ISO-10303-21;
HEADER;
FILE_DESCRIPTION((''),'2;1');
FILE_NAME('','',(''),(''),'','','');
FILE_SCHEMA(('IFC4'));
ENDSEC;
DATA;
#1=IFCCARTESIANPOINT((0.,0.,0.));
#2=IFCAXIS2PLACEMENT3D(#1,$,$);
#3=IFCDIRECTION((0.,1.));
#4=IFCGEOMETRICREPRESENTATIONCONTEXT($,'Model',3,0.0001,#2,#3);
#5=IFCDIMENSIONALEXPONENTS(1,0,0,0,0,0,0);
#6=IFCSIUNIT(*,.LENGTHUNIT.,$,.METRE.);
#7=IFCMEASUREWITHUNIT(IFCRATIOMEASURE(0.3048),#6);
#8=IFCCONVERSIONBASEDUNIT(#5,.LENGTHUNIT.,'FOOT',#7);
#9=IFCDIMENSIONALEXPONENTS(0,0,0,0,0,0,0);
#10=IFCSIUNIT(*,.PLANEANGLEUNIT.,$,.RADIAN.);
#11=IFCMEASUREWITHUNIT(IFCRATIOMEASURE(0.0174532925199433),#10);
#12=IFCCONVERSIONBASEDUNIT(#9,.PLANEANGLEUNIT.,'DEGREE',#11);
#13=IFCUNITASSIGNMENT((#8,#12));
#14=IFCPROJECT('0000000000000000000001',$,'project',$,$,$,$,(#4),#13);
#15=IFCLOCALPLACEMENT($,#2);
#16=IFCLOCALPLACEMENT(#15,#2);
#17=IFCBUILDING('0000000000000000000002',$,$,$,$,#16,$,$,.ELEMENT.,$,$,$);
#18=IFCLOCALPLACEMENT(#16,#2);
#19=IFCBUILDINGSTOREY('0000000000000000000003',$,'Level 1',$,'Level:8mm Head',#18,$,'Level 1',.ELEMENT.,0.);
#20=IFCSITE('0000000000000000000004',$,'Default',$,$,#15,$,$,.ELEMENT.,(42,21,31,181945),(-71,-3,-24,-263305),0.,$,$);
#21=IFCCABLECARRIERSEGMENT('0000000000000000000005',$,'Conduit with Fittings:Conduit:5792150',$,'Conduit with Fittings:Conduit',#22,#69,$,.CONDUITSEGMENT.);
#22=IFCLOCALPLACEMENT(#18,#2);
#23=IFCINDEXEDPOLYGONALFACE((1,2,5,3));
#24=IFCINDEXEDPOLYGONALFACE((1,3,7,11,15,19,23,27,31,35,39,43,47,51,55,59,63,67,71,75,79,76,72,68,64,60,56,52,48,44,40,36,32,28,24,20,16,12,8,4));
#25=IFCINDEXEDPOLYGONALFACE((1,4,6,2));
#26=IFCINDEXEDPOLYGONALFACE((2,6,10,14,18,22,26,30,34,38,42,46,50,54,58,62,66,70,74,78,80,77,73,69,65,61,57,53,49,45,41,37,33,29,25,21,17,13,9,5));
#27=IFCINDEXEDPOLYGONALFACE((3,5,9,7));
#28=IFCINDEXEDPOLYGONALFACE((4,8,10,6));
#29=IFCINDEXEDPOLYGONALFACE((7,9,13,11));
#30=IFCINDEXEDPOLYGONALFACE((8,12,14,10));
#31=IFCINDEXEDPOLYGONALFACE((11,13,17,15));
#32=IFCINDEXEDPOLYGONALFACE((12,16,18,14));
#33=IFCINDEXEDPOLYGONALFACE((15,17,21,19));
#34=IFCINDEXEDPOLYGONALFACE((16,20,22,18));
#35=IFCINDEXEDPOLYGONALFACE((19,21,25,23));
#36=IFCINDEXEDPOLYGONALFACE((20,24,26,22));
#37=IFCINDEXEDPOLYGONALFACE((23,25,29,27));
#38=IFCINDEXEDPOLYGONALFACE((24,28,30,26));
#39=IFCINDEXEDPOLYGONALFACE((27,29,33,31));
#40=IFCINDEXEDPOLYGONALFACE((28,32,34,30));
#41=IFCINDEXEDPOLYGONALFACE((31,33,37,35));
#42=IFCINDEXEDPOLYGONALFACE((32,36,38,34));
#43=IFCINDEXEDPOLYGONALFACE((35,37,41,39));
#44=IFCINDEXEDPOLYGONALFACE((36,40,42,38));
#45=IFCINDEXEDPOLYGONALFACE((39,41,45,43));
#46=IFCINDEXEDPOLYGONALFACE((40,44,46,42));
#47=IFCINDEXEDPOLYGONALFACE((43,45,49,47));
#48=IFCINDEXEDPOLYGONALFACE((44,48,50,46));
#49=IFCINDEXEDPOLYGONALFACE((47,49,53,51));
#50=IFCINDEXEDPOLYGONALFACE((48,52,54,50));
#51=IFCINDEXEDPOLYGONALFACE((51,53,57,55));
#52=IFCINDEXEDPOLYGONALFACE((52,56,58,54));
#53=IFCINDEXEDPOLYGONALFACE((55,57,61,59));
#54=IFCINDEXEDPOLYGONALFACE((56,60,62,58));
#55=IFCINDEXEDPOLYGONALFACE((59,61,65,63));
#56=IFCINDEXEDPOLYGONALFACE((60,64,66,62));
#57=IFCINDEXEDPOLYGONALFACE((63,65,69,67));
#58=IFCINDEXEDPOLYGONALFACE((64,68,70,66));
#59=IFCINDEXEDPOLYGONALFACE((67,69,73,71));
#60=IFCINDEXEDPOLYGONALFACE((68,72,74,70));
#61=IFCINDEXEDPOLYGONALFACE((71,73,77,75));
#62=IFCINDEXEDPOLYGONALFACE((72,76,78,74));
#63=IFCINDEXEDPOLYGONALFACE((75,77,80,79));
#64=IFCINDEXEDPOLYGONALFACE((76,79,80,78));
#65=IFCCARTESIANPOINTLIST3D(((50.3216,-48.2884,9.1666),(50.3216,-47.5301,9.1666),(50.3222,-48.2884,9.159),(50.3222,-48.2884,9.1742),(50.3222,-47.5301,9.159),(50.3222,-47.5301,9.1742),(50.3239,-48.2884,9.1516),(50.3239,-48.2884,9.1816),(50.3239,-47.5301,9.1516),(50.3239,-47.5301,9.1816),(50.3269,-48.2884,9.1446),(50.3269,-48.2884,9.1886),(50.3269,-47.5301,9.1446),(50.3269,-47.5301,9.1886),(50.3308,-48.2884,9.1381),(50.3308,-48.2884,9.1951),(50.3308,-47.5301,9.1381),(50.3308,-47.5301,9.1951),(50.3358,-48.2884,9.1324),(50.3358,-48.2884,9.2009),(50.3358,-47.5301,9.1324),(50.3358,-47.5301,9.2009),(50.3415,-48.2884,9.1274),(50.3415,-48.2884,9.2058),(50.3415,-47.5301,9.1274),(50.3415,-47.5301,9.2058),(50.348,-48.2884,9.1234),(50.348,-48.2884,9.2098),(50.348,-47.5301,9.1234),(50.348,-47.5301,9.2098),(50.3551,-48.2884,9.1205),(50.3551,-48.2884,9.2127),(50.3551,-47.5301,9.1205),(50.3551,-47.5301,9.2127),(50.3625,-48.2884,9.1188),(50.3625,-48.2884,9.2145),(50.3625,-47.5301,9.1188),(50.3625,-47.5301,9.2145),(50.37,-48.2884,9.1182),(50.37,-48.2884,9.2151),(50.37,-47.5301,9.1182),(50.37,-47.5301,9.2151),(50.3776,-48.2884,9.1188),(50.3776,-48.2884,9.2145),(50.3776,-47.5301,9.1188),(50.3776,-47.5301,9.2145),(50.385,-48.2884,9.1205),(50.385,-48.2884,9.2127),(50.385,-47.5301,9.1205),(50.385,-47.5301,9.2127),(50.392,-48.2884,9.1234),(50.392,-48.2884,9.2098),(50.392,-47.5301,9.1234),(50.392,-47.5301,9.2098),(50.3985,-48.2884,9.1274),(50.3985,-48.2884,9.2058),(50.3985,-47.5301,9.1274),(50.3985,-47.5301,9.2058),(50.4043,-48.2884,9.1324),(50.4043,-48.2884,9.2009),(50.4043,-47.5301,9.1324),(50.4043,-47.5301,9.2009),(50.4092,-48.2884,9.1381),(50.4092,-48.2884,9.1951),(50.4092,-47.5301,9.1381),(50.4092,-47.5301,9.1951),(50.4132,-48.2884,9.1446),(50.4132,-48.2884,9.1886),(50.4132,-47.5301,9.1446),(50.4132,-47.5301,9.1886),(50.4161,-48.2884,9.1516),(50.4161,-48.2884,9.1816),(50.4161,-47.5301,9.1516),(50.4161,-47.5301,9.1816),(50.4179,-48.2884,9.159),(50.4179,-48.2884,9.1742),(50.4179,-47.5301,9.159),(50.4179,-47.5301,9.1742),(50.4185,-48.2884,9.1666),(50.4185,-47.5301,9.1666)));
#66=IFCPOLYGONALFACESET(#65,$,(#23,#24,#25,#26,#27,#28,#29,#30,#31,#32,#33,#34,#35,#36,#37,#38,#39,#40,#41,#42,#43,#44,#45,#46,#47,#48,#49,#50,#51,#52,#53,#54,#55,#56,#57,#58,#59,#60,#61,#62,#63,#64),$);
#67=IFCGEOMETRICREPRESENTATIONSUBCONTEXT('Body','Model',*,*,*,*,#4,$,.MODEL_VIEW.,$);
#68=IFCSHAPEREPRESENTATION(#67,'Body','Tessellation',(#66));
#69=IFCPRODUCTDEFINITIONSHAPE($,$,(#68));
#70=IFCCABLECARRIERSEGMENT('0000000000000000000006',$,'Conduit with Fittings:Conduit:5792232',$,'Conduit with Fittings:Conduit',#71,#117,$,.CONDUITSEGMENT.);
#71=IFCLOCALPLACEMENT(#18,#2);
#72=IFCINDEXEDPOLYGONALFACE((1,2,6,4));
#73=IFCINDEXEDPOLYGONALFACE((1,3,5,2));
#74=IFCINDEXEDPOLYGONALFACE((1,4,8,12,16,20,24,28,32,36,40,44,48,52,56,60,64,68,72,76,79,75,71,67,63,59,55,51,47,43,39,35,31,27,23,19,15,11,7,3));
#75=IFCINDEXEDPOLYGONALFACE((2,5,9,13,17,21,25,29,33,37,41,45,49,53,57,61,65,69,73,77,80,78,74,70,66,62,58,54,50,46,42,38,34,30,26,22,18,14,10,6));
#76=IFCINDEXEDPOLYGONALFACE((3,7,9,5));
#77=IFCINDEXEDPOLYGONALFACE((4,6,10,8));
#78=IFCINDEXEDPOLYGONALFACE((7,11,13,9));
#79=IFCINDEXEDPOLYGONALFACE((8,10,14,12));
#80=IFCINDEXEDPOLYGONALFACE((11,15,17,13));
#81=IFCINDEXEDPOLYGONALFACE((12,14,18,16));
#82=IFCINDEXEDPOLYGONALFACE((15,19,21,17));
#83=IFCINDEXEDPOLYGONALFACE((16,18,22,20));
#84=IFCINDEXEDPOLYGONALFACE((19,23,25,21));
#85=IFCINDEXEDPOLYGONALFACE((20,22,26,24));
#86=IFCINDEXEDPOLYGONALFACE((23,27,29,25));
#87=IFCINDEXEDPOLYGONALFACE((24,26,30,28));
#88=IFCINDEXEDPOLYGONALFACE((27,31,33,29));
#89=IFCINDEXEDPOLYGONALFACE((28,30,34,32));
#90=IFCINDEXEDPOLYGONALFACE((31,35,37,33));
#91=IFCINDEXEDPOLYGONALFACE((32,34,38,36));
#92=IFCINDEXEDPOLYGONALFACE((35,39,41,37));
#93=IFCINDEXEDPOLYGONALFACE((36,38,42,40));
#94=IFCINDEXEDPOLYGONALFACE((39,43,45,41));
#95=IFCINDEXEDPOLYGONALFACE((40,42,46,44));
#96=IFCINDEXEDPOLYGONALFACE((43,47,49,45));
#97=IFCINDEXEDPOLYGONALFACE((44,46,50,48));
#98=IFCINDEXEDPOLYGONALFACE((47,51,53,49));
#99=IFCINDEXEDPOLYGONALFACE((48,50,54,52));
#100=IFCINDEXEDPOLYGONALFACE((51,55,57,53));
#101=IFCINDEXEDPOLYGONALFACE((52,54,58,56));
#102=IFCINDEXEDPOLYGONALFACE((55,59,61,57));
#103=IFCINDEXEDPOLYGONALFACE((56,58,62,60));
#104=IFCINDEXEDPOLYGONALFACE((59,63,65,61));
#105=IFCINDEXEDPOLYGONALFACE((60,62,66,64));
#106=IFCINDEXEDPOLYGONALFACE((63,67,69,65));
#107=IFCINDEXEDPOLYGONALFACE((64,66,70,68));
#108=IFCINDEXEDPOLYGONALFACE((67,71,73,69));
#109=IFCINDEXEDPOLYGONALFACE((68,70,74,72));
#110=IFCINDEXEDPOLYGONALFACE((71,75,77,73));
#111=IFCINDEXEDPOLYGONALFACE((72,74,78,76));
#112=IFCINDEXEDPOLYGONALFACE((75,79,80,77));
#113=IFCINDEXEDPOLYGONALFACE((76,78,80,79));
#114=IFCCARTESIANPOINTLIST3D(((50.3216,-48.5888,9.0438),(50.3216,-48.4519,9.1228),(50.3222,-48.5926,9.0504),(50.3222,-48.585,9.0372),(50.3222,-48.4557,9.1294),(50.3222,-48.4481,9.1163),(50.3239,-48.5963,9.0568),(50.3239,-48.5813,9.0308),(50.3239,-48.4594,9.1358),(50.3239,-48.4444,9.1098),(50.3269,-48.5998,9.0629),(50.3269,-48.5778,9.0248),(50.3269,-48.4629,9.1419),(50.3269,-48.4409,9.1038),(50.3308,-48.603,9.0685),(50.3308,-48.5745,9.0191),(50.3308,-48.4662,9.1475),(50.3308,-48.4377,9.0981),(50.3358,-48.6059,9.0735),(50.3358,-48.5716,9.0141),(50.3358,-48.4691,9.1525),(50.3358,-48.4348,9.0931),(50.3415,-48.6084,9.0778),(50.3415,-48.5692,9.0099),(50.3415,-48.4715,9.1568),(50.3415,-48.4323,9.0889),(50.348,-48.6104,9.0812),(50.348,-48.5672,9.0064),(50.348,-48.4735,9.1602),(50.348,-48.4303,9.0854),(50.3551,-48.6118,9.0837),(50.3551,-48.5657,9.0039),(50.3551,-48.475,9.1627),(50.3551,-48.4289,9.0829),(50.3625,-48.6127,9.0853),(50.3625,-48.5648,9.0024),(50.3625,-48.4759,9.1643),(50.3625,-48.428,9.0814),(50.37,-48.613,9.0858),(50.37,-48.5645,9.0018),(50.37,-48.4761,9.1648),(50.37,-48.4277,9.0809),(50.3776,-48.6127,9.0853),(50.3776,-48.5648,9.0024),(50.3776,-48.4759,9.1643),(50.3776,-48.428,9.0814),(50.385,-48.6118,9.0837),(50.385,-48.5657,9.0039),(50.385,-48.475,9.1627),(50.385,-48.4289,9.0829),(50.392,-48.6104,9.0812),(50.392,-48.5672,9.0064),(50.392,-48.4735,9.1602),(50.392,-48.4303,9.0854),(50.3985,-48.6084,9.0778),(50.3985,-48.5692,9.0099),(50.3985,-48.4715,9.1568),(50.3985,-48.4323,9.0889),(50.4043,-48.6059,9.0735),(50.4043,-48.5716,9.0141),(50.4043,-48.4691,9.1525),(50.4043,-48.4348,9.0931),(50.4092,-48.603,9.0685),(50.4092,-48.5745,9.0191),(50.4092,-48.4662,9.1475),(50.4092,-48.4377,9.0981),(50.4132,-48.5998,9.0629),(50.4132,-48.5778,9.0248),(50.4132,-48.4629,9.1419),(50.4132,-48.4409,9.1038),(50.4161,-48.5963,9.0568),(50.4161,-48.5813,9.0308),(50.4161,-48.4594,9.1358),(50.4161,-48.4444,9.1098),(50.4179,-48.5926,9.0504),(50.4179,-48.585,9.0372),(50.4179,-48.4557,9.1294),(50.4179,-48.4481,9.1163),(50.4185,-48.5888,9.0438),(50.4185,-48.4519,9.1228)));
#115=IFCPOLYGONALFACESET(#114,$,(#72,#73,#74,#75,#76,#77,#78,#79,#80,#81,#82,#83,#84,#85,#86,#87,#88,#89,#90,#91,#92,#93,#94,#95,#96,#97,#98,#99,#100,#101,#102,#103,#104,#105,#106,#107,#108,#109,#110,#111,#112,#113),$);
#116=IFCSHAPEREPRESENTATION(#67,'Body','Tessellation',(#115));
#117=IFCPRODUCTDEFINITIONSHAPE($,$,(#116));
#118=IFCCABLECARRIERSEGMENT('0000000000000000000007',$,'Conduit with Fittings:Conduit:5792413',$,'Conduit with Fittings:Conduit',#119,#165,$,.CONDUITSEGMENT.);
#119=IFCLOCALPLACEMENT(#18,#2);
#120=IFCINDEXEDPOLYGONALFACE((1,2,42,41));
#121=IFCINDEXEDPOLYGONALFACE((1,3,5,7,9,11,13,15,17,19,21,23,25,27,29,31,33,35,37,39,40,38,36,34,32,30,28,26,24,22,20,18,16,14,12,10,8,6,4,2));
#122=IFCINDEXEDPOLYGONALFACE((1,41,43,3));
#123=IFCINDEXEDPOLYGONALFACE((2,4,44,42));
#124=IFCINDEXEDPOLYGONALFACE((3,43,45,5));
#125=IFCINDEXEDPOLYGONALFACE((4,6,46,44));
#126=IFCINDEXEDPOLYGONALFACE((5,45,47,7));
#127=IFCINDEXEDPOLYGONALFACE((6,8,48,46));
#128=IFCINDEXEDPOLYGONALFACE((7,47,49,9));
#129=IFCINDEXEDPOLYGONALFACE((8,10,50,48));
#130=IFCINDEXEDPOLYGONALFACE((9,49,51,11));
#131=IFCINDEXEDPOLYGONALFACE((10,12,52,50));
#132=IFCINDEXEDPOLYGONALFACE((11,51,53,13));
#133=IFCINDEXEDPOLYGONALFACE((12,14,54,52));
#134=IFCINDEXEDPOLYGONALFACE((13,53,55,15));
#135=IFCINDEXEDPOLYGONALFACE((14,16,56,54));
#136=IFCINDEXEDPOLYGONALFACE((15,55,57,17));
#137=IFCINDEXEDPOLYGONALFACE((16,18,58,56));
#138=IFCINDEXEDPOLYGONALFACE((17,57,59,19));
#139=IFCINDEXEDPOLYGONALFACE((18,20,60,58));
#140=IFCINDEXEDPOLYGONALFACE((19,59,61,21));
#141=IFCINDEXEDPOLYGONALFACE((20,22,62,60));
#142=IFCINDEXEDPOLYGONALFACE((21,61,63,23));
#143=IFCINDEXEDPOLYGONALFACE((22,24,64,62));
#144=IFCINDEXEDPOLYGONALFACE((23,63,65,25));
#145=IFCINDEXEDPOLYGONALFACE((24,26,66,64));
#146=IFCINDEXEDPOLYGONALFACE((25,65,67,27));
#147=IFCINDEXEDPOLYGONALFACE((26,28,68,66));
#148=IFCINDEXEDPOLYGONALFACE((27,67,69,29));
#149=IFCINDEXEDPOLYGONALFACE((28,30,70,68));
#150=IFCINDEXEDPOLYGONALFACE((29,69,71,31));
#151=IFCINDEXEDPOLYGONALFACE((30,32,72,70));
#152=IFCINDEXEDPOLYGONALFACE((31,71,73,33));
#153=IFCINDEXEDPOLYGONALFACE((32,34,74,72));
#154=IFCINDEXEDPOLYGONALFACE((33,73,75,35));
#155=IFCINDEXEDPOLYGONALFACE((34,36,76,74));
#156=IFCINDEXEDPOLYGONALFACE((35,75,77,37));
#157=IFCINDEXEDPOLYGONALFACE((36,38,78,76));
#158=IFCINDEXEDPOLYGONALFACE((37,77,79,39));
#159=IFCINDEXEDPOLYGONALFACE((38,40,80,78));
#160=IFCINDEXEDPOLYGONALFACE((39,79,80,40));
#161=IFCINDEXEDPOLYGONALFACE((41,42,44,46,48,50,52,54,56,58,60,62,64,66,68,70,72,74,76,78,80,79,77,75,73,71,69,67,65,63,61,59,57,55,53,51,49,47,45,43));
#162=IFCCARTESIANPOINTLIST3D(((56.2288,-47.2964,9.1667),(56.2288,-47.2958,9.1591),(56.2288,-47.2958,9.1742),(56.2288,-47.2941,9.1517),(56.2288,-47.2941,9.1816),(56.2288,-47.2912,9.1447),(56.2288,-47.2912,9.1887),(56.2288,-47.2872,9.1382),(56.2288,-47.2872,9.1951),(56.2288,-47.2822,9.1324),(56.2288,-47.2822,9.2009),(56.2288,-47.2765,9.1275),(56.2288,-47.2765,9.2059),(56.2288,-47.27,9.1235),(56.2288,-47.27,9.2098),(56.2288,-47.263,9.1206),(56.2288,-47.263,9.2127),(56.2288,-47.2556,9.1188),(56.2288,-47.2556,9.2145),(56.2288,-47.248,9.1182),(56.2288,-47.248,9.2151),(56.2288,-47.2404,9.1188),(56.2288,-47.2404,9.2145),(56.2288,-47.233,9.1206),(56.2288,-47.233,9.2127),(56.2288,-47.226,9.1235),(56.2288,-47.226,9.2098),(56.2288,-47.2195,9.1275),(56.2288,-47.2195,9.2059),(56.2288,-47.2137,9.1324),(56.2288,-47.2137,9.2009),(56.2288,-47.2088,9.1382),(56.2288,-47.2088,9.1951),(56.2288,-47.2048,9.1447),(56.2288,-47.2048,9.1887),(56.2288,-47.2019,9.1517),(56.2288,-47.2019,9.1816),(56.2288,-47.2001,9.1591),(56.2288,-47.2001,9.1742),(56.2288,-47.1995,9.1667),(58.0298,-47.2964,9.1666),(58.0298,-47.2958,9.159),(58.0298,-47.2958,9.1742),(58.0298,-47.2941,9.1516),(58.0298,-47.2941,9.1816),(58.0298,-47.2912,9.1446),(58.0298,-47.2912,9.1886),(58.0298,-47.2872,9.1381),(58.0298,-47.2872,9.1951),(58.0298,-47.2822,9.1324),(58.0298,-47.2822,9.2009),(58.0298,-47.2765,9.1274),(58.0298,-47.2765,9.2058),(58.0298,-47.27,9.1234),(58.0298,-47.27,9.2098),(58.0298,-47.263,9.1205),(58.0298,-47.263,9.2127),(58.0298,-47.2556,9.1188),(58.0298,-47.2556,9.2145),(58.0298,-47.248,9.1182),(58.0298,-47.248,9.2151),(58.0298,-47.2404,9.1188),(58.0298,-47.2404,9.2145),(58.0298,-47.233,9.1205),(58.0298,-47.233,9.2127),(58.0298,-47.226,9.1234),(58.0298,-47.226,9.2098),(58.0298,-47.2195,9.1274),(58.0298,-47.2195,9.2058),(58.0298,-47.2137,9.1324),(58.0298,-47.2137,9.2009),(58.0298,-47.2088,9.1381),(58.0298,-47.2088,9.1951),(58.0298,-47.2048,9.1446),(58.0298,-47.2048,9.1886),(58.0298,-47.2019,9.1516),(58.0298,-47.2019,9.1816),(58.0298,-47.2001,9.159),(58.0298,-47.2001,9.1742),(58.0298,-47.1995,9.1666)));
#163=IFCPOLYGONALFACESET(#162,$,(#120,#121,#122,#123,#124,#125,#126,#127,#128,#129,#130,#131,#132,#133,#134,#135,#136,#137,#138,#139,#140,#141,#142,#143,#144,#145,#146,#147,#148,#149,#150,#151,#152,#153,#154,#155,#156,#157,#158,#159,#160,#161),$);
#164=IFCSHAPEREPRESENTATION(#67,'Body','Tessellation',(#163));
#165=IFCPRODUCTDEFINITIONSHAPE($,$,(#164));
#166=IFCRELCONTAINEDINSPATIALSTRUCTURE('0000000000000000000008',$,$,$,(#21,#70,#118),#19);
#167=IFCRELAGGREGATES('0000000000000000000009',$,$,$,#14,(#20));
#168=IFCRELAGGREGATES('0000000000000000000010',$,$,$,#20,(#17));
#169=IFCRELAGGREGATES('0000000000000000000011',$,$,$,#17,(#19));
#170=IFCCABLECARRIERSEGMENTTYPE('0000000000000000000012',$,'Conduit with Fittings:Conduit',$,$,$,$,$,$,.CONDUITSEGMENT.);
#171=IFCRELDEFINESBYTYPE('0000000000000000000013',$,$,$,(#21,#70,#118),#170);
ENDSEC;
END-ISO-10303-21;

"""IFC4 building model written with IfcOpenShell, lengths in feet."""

from ifc_helpers import new_model, entity, si_unit, converted_unit, direction, frame, origin, place, context, subcontext, project, spatial, indexed_curve, outline, extrude, type_object, element, save


model = new_model("IFC4")

# Units and contexts
model_context = context("Model", 3, precision=0.0001, world=origin(), true_north=direction((0.0, 1.0)))
body_context = subcontext(model_context, "Body", "Model", "MODEL_VIEW")
ifc_project = project(units=[converted_unit("LENGTHUNIT", "FOOT", entity("IfcRatioMeasure", 0.3048), si_unit("LENGTHUNIT", "METRE"), dimensions=[1, 0, 0, 0, 0, 0, 0]), converted_unit("PLANEANGLEUNIT", "DEGREE", entity("IfcRatioMeasure", 0.0174532925199433), si_unit("PLANEANGLEUNIT", "RADIAN"), dimensions=[0, 0, 0, 0, 0, 0, 0])], contexts=[model_context])

# Site, building, storey
site_placement = place(None, origin())
site = spatial("IfcSite", under=ifc_project, at=site_placement, Name="Default", CompositionType="ELEMENT", RefLatitude=(42, 21, 31, 181945), RefLongitude=(-71, -3, -24, -263305), RefElevation=0.0)
building_placement = place(site_placement, origin())
building = spatial("IfcBuilding", under=site, at=building_placement, CompositionType="ELEMENT")
storey_placement = place(building_placement, origin())
storey = spatial("IfcBuildingStorey", under=building, at=storey_placement, Name="Level 1", ObjectType="Level:8mm Head", LongName="Level 1", CompositionType="ELEMENT", Elevation=0.0)

# Cable carrier segments
cable_carrier_segment_type_1 = type_object("IfcCableCarrierSegmentType", Name="Conduit with Fittings:Conduit", PredefinedType="CONDUITSEGMENT")
cable_carrier_segment_1_placement = place(storey_placement, origin())
element("IfcCableCarrierSegment", 1, at=cable_carrier_segment_1_placement, inside=storey, type_object=cable_carrier_segment_type_1, Name="Conduit with Fittings:Conduit:5792150", ObjectType="Conduit with Fittings:Conduit", PredefinedType="CONDUITSEGMENT", context=body_context, shape_type="SweptSolid", body=[
    extrude(outline(indexed_curve([(0.0485, 0.0), (0.0479, 0.0076), (0.0461, 0.015), (0.0432, 0.022), (0.0392, 0.0285), (0.0343, 0.0343), (0.0285, 0.0392), (0.022, 0.0432), (0.015, 0.0461), (0.0076, 0.0479), (0.0, 0.0485), (-0.0076, 0.0479), (-0.015, 0.0461), (-0.022, 0.0432), (-0.0285, 0.0392), (-0.0343, 0.0343), (-0.0392, 0.0285), (-0.0432, 0.022), (-0.0461, 0.015), (-0.0479, 0.0076), (-0.0485, 0.0), (-0.0479, -0.0076), (-0.0461, -0.015), (-0.0432, -0.022), (-0.0392, -0.0285), (-0.0343, -0.0343), (-0.0285, -0.0392), (-0.022, -0.0432), (-0.015, -0.0461), (-0.0076, -0.0479), (0.0, -0.0485), (0.0076, -0.0479), (0.015, -0.0461), (0.022, -0.0432), (0.0285, -0.0392), (0.0343, -0.0343), (0.0392, -0.0285), (0.0432, -0.022), (0.0461, -0.015), (0.0479, -0.0076), (0.0485, 0.0)], self_intersect=False)), frame((50.37, -48.2884, 9.1666), z_axis=(0.0, 1.0, 0.0), x_axis=(1.0, 0.0, 0.0)), (0.0, 0.0, 1.0), 0.7583),
])
cable_carrier_segment_2_placement = place(storey_placement, origin())
element("IfcCableCarrierSegment", 2, at=cable_carrier_segment_2_placement, inside=storey, type_object=cable_carrier_segment_type_1, Name="Conduit with Fittings:Conduit:5792232", ObjectType="Conduit with Fittings:Conduit", PredefinedType="CONDUITSEGMENT", context=body_context, shape_type="SweptSolid", body=[
    extrude(outline(indexed_curve([(0.0485, 0.0), (0.0479, 0.0076), (0.0461, 0.015), (0.0432, 0.022), (0.0392, 0.0285), (0.0343, 0.0343), (0.0285, 0.0392), (0.022, 0.0432), (0.015, 0.0461), (0.0076, 0.0479), (0.0, 0.0485), (-0.0076, 0.0479), (-0.015, 0.0461), (-0.022, 0.0432), (-0.0285, 0.0392), (-0.0343, 0.0343), (-0.0392, 0.0285), (-0.0432, 0.022), (-0.0461, 0.015), (-0.0479, 0.0076), (-0.0485, 0.0), (-0.0479, -0.0076), (-0.0461, -0.015), (-0.0432, -0.022), (-0.0392, -0.0285), (-0.0343, -0.0343), (-0.0285, -0.0392), (-0.022, -0.0432), (-0.015, -0.0461), (-0.0076, -0.0479), (0.0, -0.0485), (0.0076, -0.0479), (0.015, -0.0461), (0.022, -0.0432), (0.0285, -0.0392), (0.0343, -0.0343), (0.0392, -0.0285), (0.0432, -0.022), (0.0461, -0.015), (0.0479, -0.0076), (0.0485, 0.0)], self_intersect=False)), frame((50.37, -48.5888, 9.0438), z_axis=(0.0, 0.866025, 0.5), x_axis=(1.0, 0.0, 0.0)), (0.0, 0.0, 1.0), 0.158),
])
cable_carrier_segment_3_placement = place(storey_placement, origin())
element("IfcCableCarrierSegment", 3, at=cable_carrier_segment_3_placement, inside=storey, type_object=cable_carrier_segment_type_1, Name="Conduit with Fittings:Conduit:5792413", ObjectType="Conduit with Fittings:Conduit", PredefinedType="CONDUITSEGMENT", context=body_context, shape_type="SweptSolid", body=[
    extrude(outline(indexed_curve([(0.0, -0.0485), (0.0076, -0.0479), (0.015, -0.0461), (0.022, -0.0432), (0.0285, -0.0392), (0.0343, -0.0343), (0.0392, -0.0285), (0.0432, -0.022), (0.0461, -0.015), (0.0479, -0.0076), (0.0485, 0.0), (0.0479, 0.0076), (0.0461, 0.015), (0.0432, 0.022), (0.0392, 0.0285), (0.0343, 0.0343), (0.0285, 0.0392), (0.022, 0.0432), (0.015, 0.0461), (0.0076, 0.0479), (0.0, 0.0485), (-0.0076, 0.0479), (-0.015, 0.0461), (-0.022, 0.0432), (-0.0285, 0.0392), (-0.0343, 0.0343), (-0.0392, 0.0285), (-0.0432, 0.022), (-0.0461, 0.015), (-0.0479, 0.0076), (-0.0485, 0.0), (-0.0479, -0.0076), (-0.0461, -0.015), (-0.0432, -0.022), (-0.0392, -0.0285), (-0.0343, -0.0343), (-0.0285, -0.0392), (-0.022, -0.0432), (-0.015, -0.0461), (-0.0076, -0.0479), (0.0, -0.0485)], self_intersect=False)), frame((56.2288, -47.248, 9.1667), z_axis=(1.0, 0.0, 0.0), x_axis=(0.0, 0.0, -1.0)), (0.000019, 0.0, 1.0), 1.801),
])

save(model, "model.ifc")
